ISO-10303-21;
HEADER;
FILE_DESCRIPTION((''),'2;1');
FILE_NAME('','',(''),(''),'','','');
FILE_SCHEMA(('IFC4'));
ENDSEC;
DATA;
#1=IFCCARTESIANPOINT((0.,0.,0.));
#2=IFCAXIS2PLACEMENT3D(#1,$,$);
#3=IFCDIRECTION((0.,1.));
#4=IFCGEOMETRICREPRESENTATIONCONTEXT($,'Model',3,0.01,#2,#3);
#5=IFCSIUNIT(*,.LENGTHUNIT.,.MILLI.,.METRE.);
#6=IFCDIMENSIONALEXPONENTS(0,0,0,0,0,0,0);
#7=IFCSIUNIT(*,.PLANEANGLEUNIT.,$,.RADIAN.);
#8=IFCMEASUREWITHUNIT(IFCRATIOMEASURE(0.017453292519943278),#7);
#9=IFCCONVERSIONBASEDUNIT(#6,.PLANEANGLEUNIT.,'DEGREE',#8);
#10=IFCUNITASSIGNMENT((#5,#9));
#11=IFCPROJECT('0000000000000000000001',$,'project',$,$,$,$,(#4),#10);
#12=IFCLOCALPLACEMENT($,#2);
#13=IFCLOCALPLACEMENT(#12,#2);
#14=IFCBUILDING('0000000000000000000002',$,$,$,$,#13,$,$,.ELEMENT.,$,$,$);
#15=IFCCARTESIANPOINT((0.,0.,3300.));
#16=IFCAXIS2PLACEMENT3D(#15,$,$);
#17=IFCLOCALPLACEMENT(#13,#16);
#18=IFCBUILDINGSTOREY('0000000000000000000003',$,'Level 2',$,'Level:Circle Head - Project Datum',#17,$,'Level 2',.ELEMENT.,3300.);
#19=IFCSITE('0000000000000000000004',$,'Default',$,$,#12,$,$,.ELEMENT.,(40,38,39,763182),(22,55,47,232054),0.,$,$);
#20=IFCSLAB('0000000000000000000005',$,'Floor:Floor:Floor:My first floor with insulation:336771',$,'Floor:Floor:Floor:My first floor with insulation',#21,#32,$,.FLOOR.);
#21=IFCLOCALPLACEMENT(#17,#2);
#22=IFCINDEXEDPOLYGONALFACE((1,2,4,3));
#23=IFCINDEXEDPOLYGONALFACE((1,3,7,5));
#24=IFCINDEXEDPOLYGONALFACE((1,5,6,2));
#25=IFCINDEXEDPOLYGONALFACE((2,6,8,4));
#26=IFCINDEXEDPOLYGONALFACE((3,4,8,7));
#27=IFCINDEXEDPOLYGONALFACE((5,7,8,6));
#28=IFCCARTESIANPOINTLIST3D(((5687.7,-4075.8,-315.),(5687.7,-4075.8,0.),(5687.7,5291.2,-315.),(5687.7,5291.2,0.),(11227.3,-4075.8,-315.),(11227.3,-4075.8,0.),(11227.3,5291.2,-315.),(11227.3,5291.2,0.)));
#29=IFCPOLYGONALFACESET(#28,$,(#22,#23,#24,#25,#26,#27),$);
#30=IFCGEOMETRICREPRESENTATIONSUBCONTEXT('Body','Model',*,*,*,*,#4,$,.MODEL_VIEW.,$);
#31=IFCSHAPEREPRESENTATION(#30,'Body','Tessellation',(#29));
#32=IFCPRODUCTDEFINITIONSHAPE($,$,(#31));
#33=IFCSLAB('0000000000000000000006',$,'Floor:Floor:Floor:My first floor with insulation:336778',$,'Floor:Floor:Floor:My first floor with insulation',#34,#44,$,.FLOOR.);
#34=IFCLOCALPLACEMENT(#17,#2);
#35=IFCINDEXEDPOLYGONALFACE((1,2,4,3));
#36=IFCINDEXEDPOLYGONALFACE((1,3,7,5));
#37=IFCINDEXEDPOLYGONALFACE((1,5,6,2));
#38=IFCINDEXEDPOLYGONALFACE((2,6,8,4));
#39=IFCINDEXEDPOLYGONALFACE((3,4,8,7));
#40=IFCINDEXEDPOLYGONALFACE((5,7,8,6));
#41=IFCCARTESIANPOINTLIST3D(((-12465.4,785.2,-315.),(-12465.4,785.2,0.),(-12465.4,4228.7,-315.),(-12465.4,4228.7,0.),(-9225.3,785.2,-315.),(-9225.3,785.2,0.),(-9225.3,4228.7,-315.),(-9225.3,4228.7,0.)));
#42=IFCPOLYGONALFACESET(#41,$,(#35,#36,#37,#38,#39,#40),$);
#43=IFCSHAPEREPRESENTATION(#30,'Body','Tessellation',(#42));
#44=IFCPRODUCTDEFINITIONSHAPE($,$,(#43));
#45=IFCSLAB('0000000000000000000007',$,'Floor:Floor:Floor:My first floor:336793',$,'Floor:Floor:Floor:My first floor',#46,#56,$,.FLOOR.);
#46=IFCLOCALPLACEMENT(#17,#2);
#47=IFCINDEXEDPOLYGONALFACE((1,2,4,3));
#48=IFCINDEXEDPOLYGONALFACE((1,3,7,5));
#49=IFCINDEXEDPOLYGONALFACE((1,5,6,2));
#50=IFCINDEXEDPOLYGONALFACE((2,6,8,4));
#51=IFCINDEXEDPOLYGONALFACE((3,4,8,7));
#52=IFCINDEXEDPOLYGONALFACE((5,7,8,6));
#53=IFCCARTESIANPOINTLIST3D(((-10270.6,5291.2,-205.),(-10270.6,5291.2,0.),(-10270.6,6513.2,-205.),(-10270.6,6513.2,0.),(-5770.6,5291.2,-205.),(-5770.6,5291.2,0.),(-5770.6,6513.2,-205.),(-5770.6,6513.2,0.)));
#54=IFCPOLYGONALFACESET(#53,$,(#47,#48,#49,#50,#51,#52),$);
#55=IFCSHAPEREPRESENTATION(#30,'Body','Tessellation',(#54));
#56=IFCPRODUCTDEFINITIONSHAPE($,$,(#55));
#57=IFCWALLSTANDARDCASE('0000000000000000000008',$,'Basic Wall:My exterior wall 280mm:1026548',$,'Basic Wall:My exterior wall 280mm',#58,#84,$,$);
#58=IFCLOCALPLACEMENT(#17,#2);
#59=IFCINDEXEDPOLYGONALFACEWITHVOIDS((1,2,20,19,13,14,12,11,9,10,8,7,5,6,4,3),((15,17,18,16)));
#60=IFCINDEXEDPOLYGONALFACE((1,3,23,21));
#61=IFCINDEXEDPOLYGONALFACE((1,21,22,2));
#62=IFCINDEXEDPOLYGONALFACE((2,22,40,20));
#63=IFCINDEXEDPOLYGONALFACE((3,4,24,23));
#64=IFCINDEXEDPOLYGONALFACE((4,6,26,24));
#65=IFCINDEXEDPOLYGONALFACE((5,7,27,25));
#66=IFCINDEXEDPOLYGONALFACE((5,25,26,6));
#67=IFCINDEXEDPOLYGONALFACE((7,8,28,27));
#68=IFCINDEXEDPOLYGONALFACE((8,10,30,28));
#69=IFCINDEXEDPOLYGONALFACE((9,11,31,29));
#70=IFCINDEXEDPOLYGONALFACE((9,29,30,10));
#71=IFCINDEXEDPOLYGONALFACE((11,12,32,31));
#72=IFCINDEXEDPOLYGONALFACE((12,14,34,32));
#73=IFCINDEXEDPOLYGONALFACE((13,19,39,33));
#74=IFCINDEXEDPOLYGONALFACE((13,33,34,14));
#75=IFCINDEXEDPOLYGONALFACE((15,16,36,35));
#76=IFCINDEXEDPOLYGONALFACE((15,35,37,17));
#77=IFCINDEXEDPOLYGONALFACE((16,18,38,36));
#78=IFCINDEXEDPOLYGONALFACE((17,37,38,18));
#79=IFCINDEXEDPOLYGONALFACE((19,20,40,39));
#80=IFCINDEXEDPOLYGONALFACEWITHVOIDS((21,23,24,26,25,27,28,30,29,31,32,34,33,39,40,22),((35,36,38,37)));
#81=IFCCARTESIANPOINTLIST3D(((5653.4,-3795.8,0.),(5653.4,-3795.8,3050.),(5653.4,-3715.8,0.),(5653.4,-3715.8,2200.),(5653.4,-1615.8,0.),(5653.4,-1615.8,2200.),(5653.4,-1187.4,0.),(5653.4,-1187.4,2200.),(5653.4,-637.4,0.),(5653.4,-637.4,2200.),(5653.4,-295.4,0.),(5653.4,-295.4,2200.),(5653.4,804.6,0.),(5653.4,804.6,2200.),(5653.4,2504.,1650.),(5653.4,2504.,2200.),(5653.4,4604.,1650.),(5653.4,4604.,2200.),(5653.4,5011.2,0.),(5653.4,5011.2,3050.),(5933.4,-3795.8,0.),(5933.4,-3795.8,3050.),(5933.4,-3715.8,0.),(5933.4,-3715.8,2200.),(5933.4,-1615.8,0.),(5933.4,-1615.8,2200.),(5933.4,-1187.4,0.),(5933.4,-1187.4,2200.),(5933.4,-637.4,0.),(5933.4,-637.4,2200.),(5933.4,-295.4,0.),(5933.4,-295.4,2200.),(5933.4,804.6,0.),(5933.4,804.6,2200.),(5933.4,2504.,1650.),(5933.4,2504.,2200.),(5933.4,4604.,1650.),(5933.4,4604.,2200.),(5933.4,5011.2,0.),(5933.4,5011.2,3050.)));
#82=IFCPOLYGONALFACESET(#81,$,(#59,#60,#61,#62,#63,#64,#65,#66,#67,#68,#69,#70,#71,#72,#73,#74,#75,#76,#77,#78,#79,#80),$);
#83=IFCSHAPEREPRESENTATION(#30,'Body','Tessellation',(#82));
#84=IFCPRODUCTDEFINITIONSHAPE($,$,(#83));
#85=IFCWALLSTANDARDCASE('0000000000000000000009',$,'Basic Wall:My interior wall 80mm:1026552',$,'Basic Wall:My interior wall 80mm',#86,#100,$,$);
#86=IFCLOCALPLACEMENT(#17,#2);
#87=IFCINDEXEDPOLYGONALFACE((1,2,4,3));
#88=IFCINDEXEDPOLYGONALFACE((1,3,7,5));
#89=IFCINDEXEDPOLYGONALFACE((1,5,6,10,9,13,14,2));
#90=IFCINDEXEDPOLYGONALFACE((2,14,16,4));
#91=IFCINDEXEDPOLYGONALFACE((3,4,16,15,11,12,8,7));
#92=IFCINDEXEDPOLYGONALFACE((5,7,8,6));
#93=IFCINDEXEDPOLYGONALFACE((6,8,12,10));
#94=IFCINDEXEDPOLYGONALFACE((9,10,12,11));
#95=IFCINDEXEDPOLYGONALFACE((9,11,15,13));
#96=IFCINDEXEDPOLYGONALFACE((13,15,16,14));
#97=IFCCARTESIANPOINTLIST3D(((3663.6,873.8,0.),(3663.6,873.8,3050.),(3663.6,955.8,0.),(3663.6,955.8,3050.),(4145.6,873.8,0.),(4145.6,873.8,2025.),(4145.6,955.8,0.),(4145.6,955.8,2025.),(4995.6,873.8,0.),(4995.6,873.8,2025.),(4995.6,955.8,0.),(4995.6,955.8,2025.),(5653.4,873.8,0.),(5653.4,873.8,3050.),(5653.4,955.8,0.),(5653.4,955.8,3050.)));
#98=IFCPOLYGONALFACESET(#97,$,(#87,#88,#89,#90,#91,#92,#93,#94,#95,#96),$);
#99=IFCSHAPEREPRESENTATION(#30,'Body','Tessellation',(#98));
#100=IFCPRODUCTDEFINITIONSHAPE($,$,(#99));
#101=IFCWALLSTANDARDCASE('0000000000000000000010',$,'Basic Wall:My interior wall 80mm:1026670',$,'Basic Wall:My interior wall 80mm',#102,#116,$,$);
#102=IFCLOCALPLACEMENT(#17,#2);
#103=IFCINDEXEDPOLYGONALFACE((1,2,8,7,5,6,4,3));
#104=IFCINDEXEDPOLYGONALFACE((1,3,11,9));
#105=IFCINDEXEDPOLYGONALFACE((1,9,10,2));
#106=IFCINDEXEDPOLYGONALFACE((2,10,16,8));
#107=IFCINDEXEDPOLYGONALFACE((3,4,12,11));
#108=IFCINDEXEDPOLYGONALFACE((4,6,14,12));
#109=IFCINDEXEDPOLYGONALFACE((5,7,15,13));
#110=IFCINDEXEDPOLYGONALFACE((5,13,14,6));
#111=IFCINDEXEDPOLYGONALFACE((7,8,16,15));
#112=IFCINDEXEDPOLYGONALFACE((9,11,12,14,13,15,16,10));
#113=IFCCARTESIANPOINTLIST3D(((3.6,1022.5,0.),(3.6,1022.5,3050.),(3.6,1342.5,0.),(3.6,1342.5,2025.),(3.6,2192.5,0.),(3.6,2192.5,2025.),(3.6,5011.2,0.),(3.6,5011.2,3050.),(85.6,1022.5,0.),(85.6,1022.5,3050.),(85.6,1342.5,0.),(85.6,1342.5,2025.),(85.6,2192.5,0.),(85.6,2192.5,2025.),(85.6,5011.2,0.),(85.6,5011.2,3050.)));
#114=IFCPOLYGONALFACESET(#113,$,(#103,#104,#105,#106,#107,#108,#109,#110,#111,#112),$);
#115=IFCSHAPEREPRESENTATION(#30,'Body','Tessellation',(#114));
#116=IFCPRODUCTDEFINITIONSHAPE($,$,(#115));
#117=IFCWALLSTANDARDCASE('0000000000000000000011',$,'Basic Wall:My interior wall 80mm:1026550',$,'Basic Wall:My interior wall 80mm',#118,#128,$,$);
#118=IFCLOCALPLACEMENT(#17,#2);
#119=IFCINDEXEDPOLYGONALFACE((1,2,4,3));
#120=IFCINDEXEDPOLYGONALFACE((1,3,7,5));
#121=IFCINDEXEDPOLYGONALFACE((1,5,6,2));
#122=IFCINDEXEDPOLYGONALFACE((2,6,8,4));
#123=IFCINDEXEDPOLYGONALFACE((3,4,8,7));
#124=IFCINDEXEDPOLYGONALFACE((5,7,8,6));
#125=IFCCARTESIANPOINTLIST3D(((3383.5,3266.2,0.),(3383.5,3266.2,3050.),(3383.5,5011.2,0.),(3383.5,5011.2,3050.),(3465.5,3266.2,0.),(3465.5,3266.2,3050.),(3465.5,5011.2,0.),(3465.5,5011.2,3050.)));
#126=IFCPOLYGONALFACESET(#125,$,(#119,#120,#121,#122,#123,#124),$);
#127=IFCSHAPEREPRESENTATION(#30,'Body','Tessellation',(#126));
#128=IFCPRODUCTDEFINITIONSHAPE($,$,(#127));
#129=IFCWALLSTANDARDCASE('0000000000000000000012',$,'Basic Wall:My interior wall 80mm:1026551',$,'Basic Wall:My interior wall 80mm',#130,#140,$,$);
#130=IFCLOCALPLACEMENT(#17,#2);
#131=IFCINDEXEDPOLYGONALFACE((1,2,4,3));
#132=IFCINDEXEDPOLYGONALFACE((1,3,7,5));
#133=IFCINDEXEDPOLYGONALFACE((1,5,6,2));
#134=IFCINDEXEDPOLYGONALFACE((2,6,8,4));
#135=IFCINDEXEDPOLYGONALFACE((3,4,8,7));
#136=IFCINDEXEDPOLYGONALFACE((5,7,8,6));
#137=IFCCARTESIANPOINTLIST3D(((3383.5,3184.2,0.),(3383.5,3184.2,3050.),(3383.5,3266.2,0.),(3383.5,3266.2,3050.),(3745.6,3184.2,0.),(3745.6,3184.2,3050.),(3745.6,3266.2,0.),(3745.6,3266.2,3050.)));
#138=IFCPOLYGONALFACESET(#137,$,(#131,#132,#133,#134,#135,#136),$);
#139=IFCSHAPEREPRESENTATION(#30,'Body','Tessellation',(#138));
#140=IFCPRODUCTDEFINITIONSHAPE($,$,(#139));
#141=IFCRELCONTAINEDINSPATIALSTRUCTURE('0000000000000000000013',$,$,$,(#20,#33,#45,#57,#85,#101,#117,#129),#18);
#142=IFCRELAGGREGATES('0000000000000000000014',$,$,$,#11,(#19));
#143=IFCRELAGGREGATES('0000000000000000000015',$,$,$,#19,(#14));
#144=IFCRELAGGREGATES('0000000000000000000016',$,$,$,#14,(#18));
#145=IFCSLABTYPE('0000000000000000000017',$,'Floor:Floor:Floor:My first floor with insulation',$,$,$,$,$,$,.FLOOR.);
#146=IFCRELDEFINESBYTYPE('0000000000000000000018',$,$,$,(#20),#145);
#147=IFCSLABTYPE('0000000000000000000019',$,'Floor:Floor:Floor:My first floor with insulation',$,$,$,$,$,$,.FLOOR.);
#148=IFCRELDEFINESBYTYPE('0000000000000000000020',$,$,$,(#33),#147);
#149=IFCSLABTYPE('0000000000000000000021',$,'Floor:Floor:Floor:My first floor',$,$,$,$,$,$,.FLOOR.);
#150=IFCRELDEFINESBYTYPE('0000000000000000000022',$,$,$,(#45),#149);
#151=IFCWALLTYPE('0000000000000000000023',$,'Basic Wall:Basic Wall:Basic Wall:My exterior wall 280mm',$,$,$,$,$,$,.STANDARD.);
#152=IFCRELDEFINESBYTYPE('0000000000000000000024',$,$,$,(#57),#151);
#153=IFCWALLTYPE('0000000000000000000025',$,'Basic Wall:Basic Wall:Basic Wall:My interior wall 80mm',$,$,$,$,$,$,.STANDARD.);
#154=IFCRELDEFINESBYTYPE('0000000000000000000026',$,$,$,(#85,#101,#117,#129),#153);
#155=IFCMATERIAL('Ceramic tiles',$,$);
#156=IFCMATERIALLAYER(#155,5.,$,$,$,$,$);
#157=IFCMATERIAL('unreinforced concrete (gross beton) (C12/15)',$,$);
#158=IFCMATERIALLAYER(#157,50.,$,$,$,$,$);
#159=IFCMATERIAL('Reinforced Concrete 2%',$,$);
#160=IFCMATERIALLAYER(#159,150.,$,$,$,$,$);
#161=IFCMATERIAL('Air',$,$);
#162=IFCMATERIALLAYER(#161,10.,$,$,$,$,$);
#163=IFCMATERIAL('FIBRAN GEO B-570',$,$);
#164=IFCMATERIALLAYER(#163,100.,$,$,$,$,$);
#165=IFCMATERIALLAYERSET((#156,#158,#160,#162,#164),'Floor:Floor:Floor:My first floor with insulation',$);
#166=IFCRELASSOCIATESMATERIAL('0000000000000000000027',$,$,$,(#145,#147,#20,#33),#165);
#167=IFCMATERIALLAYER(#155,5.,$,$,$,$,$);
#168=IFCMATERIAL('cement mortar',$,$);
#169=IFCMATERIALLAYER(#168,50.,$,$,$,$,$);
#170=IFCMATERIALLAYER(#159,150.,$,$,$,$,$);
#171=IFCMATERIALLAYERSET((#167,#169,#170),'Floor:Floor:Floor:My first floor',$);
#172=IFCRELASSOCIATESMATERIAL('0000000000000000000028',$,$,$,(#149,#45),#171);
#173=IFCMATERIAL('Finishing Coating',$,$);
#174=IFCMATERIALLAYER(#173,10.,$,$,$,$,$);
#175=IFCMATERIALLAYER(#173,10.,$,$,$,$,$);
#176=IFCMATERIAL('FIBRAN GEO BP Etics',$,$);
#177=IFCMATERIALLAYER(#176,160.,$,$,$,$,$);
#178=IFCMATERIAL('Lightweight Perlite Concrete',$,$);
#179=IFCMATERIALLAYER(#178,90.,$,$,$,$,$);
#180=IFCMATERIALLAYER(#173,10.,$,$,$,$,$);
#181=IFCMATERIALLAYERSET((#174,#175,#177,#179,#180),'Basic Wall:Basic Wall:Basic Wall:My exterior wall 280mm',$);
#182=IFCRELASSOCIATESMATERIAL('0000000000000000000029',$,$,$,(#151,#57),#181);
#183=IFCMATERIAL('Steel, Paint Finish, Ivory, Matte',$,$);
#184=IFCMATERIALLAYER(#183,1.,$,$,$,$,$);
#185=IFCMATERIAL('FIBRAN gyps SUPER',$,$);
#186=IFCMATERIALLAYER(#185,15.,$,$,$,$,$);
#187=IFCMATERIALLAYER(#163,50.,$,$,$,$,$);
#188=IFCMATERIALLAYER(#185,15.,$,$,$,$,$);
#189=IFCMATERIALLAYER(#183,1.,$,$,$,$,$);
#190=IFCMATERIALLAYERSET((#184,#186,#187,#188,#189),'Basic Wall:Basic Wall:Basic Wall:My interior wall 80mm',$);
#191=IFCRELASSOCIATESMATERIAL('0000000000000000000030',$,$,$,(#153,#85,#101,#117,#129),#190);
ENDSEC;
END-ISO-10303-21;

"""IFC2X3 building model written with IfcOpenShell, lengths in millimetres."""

from ifc_helpers import new_model, entity, si_unit, converted_unit, direction, frame, frame_2d, origin, origin_2d_with_axis, place, context, subcontext, project, spatial, rectangle, extrude, material, layer, layer_set, layer_usage, type_object, element, save


model = new_model("IFC2X3")

# Units and contexts
model_context = context("Model", 3, precision=0.01, world=origin(), true_north=direction((0.0, 1.0)))
body_context = subcontext(model_context, "Body", "Model", "MODEL_VIEW")
ifc_project = project(units=[si_unit("LENGTHUNIT", "METRE", prefix="MILLI"), converted_unit("PLANEANGLEUNIT", "DEGREE", entity("IfcRatioMeasure", 0.017453292519943278), si_unit("PLANEANGLEUNIT", "RADIAN"), dimensions=[0, 0, 0, 0, 0, 0, 0])], contexts=[model_context])

# Site, building, storey
site_placement = place(None, origin())
site = spatial("IfcSite", under=ifc_project, at=site_placement, Name="Default", CompositionType="ELEMENT", RefLatitude=(40, 38, 39, 763182), RefLongitude=(22, 55, 47, 232054), RefElevation=0.0)
building_placement = place(site_placement, origin())
building = spatial("IfcBuilding", under=site, at=building_placement, CompositionType="ELEMENT")
storey_placement = place(building_placement, frame((0.0, 0.0, 3300.0)))
storey = spatial("IfcBuildingStorey", under=building, at=storey_placement, Name="Level 2", ObjectType="Level:Circle Head - Project Datum", LongName="Level 2", CompositionType="ELEMENT", Elevation=3300.0)

# Shared definitions
ifc_material_1 = material(Name="FIBRAN gyps SUPER")

# Slabs
ifc_material_2 = material(Name="Ceramic tiles")
ifc_layer_1 = layer(ifc_material_2, 5.0)
ifc_material_3 = material(Name="unreinforced concrete (gross beton) (C12/15)")
ifc_layer_2 = layer(ifc_material_3, 50.0)
ifc_material_4 = material(Name="Reinforced Concrete 2%")
ifc_layer_3 = layer(ifc_material_4, 150.0)
ifc_material_5 = material(Name="Air")
ifc_layer_4 = layer(ifc_material_5, 10.0)
ifc_material_6 = material(Name="FIBRAN GEO B-570")
ifc_layer_5 = layer(ifc_material_6, 100.0)
ifc_layer_set_1 = layer_set([ifc_layer_1, ifc_layer_2, ifc_layer_3, ifc_layer_4, ifc_layer_5], Name="Floor:Floor:Floor:My first floor with insulation")
ifc_layer_usage_1 = layer_usage(ifc_layer_set_1, "AXIS3", "POSITIVE", 0.0)
slab_type_1 = type_object("IfcSlabType", Name="Floor:Floor:Floor:My first floor with insulation", PredefinedType="FLOOR", material=ifc_layer_set_1)
slab_1_placement = place(storey_placement, origin())
element("IfcSlab", 1, at=slab_1_placement, inside=storey, type_object=slab_type_1, material=ifc_layer_usage_1, Name="Floor:Floor:Floor:My first floor with insulation:336771", ObjectType="Floor:Floor:Floor:My first floor with insulation", PredefinedType="FLOOR", context=body_context, shape_type="SweptSolid", body=[
    extrude(rectangle(XDim=9367.0, YDim=5539.6, at=origin_2d_with_axis()), frame((8457.5, 607.7, 0.0), z_axis=(0.0, 0.0, -1.0), x_axis=(0.0, 1.0, 0.0)), (0.0, 0.0, 1.0), 315.0),
])
ifc_layer_usage_2 = layer_usage(ifc_layer_set_1, "AXIS3", "POSITIVE", 0.0)
slab_type_2 = type_object("IfcSlabType", Name="Floor:Floor:Floor:My first floor with insulation", PredefinedType="FLOOR", material=ifc_layer_set_1)
slab_2_placement = place(storey_placement, origin())
element("IfcSlab", 2, at=slab_2_placement, inside=storey, type_object=slab_type_2, material=ifc_layer_usage_2, Name="Floor:Floor:Floor:My first floor with insulation:336778", ObjectType="Floor:Floor:Floor:My first floor with insulation", PredefinedType="FLOOR", context=body_context, shape_type="SweptSolid", body=[
    extrude(rectangle(XDim=3443.5, YDim=3240.0, at=frame_2d((0.0, 0.0), x_axis=(1.0, 0.0))), frame((-10845.4, 2506.9, 0.0), z_axis=(0.0, 0.0, -1.0), x_axis=(0.0, 1.0, 0.0)), (0.0, 0.0, 1.0), 315.0),
])
ifc_layer_6 = layer(ifc_material_2, 5.0)
ifc_material_7 = material(Name="cement mortar")
ifc_layer_7 = layer(ifc_material_7, 50.0)
ifc_layer_8 = layer(ifc_material_4, 150.0)
ifc_layer_set_2 = layer_set([ifc_layer_6, ifc_layer_7, ifc_layer_8], Name="Floor:Floor:Floor:My first floor")
ifc_layer_usage_3 = layer_usage(ifc_layer_set_2, "AXIS3", "POSITIVE", 0.0)
slab_type_3 = type_object("IfcSlabType", Name="Floor:Floor:Floor:My first floor", PredefinedType="FLOOR", material=ifc_layer_set_2)
slab_3_placement = place(storey_placement, origin())
element("IfcSlab", 3, at=slab_3_placement, inside=storey, type_object=slab_type_3, material=ifc_layer_usage_3, Name="Floor:Floor:Floor:My first floor:336793", ObjectType="Floor:Floor:Floor:My first floor", PredefinedType="FLOOR", context=body_context, shape_type="SweptSolid", body=[
    extrude(rectangle(XDim=1222.0, YDim=4500.0, at=frame_2d((0.0, 0.0), x_axis=(1.0, 0.0))), frame((-8020.6, 5902.2, 0.0), z_axis=(0.0, 0.0, -1.0), x_axis=(0.0, 1.0, 0.0)), (0.0, 0.0, 1.0), 205.0),
])

# Wall, openings
ifc_material_8 = material(Name="Finishing Coating")
ifc_layer_9 = layer(ifc_material_8, 10.0)
ifc_layer_10 = layer(ifc_material_8, 10.0)
ifc_material_9 = material(Name="FIBRAN GEO BP Etics")
ifc_layer_11 = layer(ifc_material_9, 160.0)
ifc_material_10 = material(Name="Lightweight Perlite Concrete")
ifc_layer_12 = layer(ifc_material_10, 90.0)
ifc_layer_13 = layer(ifc_material_8, 10.0)
ifc_layer_set_3 = layer_set([ifc_layer_9, ifc_layer_10, ifc_layer_11, ifc_layer_12, ifc_layer_13], Name="Basic Wall:Basic Wall:Basic Wall:My exterior wall 280mm")
ifc_layer_usage_4 = layer_usage(ifc_layer_set_3, "AXIS2", "NEGATIVE", 140.0)
wall_type_1 = type_object("IfcWallType", Name="Basic Wall:Basic Wall:Basic Wall:My exterior wall 280mm", PredefinedType="STANDARD", material=ifc_layer_set_3)
wall_1_placement = place(storey_placement, frame((5793.4, 5011.2, 0.0), z_axis=(0.0, 0.0, 1.0), x_axis=(0.0, -1.0, 0.0)))
wall_1 = element("IfcWallStandardCase", 4, at=wall_1_placement, inside=storey, type_object=wall_type_1, material=ifc_layer_usage_4, Name="Basic Wall:My exterior wall 280mm:1026548", ObjectType="Basic Wall:My exterior wall 280mm", context=body_context, shape_type="SweptSolid", body=[
    extrude(rectangle(XDim=8807.0, YDim=280.0, at=frame_2d((4403.5, 0.0), x_axis=(1.0, 0.0))), origin(), (0.0, 0.0, 1.0), 3050.0),
])
opening_1_placement = place(wall_1_placement, origin())
element("IfcOpeningElement", 5, at=opening_1_placement, cuts=wall_1, ObjectType="Opening", context=body_context, shape_type="SweptSolid", body=[
    extrude(rectangle(XDim=2200.0, YDim=1100.0, at=frame_2d((0.0, 0.0), x_axis=(1.0, 0.0))), frame((4756.6, -140.0, 1100.0), z_axis=(0.0, 1.0, 0.0), x_axis=(0.0, 0.0, -1.0)), (0.0, 0.0, 1.0), 280.0),
])
opening_2_placement = place(wall_1_placement, origin())
element("IfcOpeningElement", 6, at=opening_2_placement, cuts=wall_1, ObjectType="Opening", context=body_context, shape_type="SweptSolid", body=[
    extrude(rectangle(XDim=2200.0, YDim=550.0, at=frame_2d((0.0, 0.0), x_axis=(1.0, 0.0))), frame((5923.6, -140.0, 1100.0), z_axis=(0.0, 1.0, 0.0), x_axis=(0.0, 0.0, -1.0)), (0.0, 0.0, 1.0), 280.0),
])
opening_3_placement = place(wall_1_placement, origin())
element("IfcOpeningElement", 7, at=opening_3_placement, cuts=wall_1, ObjectType="Opening", context=body_context, shape_type="SweptSolid", body=[
    extrude(rectangle(XDim=2200.0, YDim=2100.0, at=frame_2d((0.0, 0.0), x_axis=(1.0, 0.0))), frame((7677.0, -140.0, 1100.0), z_axis=(0.0, 1.0, 0.0), x_axis=(0.0, 0.0, -1.0)), (0.0, 0.0, 1.0), 280.0),
])
opening_4_placement = place(wall_1_placement, origin())
element("IfcOpeningElement", 8, at=opening_4_placement, cuts=wall_1, ObjectType="Opening", context=body_context, shape_type="SweptSolid", body=[
    extrude(rectangle(XDim=550.0, YDim=2100.0, at=origin_2d_with_axis()), frame((1457.1, -140.0, 1925.0), z_axis=(0.0, 1.0, 0.0), x_axis=(0.0, 0.0, -1.0)), (0.0, 0.0, 1.0), 280.0),
])

# Walls, openings
ifc_material_11 = material(Name="Steel, Paint Finish, Ivory, Matte")
ifc_layer_14 = layer(ifc_material_11, 1.0)
ifc_layer_15 = layer(ifc_material_1, 15.0)
ifc_layer_16 = layer(ifc_material_6, 50.0)
ifc_layer_17 = layer(ifc_material_1, 15.0)
ifc_layer_18 = layer(ifc_material_11, 1.0)
ifc_layer_set_4 = layer_set([ifc_layer_14, ifc_layer_15, ifc_layer_16, ifc_layer_17, ifc_layer_18], Name="Basic Wall:Basic Wall:Basic Wall:My interior wall 80mm")
ifc_layer_usage_5 = layer_usage(ifc_layer_set_4, "AXIS2", "NEGATIVE", 41.0)
wall_type_2 = type_object("IfcWallType", Name="Basic Wall:Basic Wall:Basic Wall:My interior wall 80mm", PredefinedType="STANDARD", material=ifc_layer_set_4)
wall_2_placement = place(storey_placement, frame((3663.6, 914.8, 0.0)))
wall_2 = element("IfcWallStandardCase", 9, at=wall_2_placement, inside=storey, type_object=wall_type_2, material=ifc_layer_usage_5, Name="Basic Wall:My interior wall 80mm:1026552", ObjectType="Basic Wall:My interior wall 80mm", context=body_context, shape_type="SweptSolid", body=[
    extrude(rectangle(XDim=1989.8, YDim=82.0, at=frame_2d((994.9, 0.0), x_axis=(1.0, 0.0))), origin(), (0.0, 0.0, 1.0), 3050.0),
])
opening_5_placement = place(wall_2_placement, origin())
element("IfcOpeningElement", 10, at=opening_5_placement, cuts=wall_2, ObjectType="Opening", context=body_context, shape_type="SweptSolid", body=[
    extrude(rectangle(XDim=2025.0, YDim=850.0, at=frame_2d((0.0, 0.0), x_axis=(1.0, 0.0))), frame((907.0, -41.0, 1012.5), z_axis=(0.0, 1.0, 0.0), x_axis=(0.0, 0.0, -1.0)), (0.0, 0.0, 1.0), 82.0),
])
ifc_layer_usage_6 = layer_usage(ifc_layer_set_4, "AXIS2", "NEGATIVE", 41.0)
wall_3_placement = place(storey_placement, frame((44.6, 5011.2, 0.0), z_axis=(0.0, 0.0, 1.0), x_axis=(0.0, -1.0, 0.0)))
wall_3 = element("IfcWallStandardCase", 11, at=wall_3_placement, inside=storey, type_object=wall_type_2, material=ifc_layer_usage_6, Name="Basic Wall:My interior wall 80mm:1026670", ObjectType="Basic Wall:My interior wall 80mm", context=body_context, shape_type="SweptSolid", body=[
    extrude(rectangle(XDim=3988.6, YDim=82.0, at=frame_2d((1994.3, 0.0), x_axis=(1.0, 0.0))), origin(), (0.0, 0.0, 1.0), 3050.0),
])
opening_6_placement = place(wall_3_placement, origin())
element("IfcOpeningElement", 12, at=opening_6_placement, cuts=wall_3, ObjectType="Opening", context=body_context, shape_type="SweptSolid", body=[
    extrude(rectangle(XDim=2025.0, YDim=850.0, at=frame_2d((0.0, 0.0), x_axis=(1.0, 0.0))), frame((3243.6, -41.0, 1012.5), z_axis=(0.0, 1.0, 0.0), x_axis=(0.0, 0.0, -1.0)), (0.0, 0.0, 1.0), 82.0),
])

# Walls
ifc_layer_usage_7 = layer_usage(ifc_layer_set_4, "AXIS2", "NEGATIVE", 41.0)
wall_4_placement = place(storey_placement, frame((3424.5, 5011.2, 0.0), z_axis=(0.0, 0.0, 1.0), x_axis=(0.0, -1.0, 0.0)))
element("IfcWallStandardCase", 13, at=wall_4_placement, inside=storey, type_object=wall_type_2, material=ifc_layer_usage_7, Name="Basic Wall:My interior wall 80mm:1026550", ObjectType="Basic Wall:My interior wall 80mm", context=body_context, shape_type="SweptSolid", body=[
    extrude(rectangle(XDim=1745.0, YDim=82.0, at=frame_2d((872.5, 0.0), x_axis=(-1.0, 0.0))), origin(), (0.0, 0.0, 1.0), 3050.0),
])
ifc_layer_usage_8 = layer_usage(ifc_layer_set_4, "AXIS2", "NEGATIVE", 41.0)
wall_5_placement = place(storey_placement, frame((3383.5, 3225.2, 0.0)))
element("IfcWallStandardCase", 14, at=wall_5_placement, inside=storey, type_object=wall_type_2, material=ifc_layer_usage_8, Name="Basic Wall:My interior wall 80mm:1026551", ObjectType="Basic Wall:My interior wall 80mm", context=body_context, shape_type="SweptSolid", body=[
    extrude(rectangle(XDim=362.1, YDim=82.0, at=frame_2d((181.0, 0.0), x_axis=(-1.0, 0.0))), origin(), (0.0, 0.0, 1.0), 3050.0),
])

save(model, "model.ifc")
